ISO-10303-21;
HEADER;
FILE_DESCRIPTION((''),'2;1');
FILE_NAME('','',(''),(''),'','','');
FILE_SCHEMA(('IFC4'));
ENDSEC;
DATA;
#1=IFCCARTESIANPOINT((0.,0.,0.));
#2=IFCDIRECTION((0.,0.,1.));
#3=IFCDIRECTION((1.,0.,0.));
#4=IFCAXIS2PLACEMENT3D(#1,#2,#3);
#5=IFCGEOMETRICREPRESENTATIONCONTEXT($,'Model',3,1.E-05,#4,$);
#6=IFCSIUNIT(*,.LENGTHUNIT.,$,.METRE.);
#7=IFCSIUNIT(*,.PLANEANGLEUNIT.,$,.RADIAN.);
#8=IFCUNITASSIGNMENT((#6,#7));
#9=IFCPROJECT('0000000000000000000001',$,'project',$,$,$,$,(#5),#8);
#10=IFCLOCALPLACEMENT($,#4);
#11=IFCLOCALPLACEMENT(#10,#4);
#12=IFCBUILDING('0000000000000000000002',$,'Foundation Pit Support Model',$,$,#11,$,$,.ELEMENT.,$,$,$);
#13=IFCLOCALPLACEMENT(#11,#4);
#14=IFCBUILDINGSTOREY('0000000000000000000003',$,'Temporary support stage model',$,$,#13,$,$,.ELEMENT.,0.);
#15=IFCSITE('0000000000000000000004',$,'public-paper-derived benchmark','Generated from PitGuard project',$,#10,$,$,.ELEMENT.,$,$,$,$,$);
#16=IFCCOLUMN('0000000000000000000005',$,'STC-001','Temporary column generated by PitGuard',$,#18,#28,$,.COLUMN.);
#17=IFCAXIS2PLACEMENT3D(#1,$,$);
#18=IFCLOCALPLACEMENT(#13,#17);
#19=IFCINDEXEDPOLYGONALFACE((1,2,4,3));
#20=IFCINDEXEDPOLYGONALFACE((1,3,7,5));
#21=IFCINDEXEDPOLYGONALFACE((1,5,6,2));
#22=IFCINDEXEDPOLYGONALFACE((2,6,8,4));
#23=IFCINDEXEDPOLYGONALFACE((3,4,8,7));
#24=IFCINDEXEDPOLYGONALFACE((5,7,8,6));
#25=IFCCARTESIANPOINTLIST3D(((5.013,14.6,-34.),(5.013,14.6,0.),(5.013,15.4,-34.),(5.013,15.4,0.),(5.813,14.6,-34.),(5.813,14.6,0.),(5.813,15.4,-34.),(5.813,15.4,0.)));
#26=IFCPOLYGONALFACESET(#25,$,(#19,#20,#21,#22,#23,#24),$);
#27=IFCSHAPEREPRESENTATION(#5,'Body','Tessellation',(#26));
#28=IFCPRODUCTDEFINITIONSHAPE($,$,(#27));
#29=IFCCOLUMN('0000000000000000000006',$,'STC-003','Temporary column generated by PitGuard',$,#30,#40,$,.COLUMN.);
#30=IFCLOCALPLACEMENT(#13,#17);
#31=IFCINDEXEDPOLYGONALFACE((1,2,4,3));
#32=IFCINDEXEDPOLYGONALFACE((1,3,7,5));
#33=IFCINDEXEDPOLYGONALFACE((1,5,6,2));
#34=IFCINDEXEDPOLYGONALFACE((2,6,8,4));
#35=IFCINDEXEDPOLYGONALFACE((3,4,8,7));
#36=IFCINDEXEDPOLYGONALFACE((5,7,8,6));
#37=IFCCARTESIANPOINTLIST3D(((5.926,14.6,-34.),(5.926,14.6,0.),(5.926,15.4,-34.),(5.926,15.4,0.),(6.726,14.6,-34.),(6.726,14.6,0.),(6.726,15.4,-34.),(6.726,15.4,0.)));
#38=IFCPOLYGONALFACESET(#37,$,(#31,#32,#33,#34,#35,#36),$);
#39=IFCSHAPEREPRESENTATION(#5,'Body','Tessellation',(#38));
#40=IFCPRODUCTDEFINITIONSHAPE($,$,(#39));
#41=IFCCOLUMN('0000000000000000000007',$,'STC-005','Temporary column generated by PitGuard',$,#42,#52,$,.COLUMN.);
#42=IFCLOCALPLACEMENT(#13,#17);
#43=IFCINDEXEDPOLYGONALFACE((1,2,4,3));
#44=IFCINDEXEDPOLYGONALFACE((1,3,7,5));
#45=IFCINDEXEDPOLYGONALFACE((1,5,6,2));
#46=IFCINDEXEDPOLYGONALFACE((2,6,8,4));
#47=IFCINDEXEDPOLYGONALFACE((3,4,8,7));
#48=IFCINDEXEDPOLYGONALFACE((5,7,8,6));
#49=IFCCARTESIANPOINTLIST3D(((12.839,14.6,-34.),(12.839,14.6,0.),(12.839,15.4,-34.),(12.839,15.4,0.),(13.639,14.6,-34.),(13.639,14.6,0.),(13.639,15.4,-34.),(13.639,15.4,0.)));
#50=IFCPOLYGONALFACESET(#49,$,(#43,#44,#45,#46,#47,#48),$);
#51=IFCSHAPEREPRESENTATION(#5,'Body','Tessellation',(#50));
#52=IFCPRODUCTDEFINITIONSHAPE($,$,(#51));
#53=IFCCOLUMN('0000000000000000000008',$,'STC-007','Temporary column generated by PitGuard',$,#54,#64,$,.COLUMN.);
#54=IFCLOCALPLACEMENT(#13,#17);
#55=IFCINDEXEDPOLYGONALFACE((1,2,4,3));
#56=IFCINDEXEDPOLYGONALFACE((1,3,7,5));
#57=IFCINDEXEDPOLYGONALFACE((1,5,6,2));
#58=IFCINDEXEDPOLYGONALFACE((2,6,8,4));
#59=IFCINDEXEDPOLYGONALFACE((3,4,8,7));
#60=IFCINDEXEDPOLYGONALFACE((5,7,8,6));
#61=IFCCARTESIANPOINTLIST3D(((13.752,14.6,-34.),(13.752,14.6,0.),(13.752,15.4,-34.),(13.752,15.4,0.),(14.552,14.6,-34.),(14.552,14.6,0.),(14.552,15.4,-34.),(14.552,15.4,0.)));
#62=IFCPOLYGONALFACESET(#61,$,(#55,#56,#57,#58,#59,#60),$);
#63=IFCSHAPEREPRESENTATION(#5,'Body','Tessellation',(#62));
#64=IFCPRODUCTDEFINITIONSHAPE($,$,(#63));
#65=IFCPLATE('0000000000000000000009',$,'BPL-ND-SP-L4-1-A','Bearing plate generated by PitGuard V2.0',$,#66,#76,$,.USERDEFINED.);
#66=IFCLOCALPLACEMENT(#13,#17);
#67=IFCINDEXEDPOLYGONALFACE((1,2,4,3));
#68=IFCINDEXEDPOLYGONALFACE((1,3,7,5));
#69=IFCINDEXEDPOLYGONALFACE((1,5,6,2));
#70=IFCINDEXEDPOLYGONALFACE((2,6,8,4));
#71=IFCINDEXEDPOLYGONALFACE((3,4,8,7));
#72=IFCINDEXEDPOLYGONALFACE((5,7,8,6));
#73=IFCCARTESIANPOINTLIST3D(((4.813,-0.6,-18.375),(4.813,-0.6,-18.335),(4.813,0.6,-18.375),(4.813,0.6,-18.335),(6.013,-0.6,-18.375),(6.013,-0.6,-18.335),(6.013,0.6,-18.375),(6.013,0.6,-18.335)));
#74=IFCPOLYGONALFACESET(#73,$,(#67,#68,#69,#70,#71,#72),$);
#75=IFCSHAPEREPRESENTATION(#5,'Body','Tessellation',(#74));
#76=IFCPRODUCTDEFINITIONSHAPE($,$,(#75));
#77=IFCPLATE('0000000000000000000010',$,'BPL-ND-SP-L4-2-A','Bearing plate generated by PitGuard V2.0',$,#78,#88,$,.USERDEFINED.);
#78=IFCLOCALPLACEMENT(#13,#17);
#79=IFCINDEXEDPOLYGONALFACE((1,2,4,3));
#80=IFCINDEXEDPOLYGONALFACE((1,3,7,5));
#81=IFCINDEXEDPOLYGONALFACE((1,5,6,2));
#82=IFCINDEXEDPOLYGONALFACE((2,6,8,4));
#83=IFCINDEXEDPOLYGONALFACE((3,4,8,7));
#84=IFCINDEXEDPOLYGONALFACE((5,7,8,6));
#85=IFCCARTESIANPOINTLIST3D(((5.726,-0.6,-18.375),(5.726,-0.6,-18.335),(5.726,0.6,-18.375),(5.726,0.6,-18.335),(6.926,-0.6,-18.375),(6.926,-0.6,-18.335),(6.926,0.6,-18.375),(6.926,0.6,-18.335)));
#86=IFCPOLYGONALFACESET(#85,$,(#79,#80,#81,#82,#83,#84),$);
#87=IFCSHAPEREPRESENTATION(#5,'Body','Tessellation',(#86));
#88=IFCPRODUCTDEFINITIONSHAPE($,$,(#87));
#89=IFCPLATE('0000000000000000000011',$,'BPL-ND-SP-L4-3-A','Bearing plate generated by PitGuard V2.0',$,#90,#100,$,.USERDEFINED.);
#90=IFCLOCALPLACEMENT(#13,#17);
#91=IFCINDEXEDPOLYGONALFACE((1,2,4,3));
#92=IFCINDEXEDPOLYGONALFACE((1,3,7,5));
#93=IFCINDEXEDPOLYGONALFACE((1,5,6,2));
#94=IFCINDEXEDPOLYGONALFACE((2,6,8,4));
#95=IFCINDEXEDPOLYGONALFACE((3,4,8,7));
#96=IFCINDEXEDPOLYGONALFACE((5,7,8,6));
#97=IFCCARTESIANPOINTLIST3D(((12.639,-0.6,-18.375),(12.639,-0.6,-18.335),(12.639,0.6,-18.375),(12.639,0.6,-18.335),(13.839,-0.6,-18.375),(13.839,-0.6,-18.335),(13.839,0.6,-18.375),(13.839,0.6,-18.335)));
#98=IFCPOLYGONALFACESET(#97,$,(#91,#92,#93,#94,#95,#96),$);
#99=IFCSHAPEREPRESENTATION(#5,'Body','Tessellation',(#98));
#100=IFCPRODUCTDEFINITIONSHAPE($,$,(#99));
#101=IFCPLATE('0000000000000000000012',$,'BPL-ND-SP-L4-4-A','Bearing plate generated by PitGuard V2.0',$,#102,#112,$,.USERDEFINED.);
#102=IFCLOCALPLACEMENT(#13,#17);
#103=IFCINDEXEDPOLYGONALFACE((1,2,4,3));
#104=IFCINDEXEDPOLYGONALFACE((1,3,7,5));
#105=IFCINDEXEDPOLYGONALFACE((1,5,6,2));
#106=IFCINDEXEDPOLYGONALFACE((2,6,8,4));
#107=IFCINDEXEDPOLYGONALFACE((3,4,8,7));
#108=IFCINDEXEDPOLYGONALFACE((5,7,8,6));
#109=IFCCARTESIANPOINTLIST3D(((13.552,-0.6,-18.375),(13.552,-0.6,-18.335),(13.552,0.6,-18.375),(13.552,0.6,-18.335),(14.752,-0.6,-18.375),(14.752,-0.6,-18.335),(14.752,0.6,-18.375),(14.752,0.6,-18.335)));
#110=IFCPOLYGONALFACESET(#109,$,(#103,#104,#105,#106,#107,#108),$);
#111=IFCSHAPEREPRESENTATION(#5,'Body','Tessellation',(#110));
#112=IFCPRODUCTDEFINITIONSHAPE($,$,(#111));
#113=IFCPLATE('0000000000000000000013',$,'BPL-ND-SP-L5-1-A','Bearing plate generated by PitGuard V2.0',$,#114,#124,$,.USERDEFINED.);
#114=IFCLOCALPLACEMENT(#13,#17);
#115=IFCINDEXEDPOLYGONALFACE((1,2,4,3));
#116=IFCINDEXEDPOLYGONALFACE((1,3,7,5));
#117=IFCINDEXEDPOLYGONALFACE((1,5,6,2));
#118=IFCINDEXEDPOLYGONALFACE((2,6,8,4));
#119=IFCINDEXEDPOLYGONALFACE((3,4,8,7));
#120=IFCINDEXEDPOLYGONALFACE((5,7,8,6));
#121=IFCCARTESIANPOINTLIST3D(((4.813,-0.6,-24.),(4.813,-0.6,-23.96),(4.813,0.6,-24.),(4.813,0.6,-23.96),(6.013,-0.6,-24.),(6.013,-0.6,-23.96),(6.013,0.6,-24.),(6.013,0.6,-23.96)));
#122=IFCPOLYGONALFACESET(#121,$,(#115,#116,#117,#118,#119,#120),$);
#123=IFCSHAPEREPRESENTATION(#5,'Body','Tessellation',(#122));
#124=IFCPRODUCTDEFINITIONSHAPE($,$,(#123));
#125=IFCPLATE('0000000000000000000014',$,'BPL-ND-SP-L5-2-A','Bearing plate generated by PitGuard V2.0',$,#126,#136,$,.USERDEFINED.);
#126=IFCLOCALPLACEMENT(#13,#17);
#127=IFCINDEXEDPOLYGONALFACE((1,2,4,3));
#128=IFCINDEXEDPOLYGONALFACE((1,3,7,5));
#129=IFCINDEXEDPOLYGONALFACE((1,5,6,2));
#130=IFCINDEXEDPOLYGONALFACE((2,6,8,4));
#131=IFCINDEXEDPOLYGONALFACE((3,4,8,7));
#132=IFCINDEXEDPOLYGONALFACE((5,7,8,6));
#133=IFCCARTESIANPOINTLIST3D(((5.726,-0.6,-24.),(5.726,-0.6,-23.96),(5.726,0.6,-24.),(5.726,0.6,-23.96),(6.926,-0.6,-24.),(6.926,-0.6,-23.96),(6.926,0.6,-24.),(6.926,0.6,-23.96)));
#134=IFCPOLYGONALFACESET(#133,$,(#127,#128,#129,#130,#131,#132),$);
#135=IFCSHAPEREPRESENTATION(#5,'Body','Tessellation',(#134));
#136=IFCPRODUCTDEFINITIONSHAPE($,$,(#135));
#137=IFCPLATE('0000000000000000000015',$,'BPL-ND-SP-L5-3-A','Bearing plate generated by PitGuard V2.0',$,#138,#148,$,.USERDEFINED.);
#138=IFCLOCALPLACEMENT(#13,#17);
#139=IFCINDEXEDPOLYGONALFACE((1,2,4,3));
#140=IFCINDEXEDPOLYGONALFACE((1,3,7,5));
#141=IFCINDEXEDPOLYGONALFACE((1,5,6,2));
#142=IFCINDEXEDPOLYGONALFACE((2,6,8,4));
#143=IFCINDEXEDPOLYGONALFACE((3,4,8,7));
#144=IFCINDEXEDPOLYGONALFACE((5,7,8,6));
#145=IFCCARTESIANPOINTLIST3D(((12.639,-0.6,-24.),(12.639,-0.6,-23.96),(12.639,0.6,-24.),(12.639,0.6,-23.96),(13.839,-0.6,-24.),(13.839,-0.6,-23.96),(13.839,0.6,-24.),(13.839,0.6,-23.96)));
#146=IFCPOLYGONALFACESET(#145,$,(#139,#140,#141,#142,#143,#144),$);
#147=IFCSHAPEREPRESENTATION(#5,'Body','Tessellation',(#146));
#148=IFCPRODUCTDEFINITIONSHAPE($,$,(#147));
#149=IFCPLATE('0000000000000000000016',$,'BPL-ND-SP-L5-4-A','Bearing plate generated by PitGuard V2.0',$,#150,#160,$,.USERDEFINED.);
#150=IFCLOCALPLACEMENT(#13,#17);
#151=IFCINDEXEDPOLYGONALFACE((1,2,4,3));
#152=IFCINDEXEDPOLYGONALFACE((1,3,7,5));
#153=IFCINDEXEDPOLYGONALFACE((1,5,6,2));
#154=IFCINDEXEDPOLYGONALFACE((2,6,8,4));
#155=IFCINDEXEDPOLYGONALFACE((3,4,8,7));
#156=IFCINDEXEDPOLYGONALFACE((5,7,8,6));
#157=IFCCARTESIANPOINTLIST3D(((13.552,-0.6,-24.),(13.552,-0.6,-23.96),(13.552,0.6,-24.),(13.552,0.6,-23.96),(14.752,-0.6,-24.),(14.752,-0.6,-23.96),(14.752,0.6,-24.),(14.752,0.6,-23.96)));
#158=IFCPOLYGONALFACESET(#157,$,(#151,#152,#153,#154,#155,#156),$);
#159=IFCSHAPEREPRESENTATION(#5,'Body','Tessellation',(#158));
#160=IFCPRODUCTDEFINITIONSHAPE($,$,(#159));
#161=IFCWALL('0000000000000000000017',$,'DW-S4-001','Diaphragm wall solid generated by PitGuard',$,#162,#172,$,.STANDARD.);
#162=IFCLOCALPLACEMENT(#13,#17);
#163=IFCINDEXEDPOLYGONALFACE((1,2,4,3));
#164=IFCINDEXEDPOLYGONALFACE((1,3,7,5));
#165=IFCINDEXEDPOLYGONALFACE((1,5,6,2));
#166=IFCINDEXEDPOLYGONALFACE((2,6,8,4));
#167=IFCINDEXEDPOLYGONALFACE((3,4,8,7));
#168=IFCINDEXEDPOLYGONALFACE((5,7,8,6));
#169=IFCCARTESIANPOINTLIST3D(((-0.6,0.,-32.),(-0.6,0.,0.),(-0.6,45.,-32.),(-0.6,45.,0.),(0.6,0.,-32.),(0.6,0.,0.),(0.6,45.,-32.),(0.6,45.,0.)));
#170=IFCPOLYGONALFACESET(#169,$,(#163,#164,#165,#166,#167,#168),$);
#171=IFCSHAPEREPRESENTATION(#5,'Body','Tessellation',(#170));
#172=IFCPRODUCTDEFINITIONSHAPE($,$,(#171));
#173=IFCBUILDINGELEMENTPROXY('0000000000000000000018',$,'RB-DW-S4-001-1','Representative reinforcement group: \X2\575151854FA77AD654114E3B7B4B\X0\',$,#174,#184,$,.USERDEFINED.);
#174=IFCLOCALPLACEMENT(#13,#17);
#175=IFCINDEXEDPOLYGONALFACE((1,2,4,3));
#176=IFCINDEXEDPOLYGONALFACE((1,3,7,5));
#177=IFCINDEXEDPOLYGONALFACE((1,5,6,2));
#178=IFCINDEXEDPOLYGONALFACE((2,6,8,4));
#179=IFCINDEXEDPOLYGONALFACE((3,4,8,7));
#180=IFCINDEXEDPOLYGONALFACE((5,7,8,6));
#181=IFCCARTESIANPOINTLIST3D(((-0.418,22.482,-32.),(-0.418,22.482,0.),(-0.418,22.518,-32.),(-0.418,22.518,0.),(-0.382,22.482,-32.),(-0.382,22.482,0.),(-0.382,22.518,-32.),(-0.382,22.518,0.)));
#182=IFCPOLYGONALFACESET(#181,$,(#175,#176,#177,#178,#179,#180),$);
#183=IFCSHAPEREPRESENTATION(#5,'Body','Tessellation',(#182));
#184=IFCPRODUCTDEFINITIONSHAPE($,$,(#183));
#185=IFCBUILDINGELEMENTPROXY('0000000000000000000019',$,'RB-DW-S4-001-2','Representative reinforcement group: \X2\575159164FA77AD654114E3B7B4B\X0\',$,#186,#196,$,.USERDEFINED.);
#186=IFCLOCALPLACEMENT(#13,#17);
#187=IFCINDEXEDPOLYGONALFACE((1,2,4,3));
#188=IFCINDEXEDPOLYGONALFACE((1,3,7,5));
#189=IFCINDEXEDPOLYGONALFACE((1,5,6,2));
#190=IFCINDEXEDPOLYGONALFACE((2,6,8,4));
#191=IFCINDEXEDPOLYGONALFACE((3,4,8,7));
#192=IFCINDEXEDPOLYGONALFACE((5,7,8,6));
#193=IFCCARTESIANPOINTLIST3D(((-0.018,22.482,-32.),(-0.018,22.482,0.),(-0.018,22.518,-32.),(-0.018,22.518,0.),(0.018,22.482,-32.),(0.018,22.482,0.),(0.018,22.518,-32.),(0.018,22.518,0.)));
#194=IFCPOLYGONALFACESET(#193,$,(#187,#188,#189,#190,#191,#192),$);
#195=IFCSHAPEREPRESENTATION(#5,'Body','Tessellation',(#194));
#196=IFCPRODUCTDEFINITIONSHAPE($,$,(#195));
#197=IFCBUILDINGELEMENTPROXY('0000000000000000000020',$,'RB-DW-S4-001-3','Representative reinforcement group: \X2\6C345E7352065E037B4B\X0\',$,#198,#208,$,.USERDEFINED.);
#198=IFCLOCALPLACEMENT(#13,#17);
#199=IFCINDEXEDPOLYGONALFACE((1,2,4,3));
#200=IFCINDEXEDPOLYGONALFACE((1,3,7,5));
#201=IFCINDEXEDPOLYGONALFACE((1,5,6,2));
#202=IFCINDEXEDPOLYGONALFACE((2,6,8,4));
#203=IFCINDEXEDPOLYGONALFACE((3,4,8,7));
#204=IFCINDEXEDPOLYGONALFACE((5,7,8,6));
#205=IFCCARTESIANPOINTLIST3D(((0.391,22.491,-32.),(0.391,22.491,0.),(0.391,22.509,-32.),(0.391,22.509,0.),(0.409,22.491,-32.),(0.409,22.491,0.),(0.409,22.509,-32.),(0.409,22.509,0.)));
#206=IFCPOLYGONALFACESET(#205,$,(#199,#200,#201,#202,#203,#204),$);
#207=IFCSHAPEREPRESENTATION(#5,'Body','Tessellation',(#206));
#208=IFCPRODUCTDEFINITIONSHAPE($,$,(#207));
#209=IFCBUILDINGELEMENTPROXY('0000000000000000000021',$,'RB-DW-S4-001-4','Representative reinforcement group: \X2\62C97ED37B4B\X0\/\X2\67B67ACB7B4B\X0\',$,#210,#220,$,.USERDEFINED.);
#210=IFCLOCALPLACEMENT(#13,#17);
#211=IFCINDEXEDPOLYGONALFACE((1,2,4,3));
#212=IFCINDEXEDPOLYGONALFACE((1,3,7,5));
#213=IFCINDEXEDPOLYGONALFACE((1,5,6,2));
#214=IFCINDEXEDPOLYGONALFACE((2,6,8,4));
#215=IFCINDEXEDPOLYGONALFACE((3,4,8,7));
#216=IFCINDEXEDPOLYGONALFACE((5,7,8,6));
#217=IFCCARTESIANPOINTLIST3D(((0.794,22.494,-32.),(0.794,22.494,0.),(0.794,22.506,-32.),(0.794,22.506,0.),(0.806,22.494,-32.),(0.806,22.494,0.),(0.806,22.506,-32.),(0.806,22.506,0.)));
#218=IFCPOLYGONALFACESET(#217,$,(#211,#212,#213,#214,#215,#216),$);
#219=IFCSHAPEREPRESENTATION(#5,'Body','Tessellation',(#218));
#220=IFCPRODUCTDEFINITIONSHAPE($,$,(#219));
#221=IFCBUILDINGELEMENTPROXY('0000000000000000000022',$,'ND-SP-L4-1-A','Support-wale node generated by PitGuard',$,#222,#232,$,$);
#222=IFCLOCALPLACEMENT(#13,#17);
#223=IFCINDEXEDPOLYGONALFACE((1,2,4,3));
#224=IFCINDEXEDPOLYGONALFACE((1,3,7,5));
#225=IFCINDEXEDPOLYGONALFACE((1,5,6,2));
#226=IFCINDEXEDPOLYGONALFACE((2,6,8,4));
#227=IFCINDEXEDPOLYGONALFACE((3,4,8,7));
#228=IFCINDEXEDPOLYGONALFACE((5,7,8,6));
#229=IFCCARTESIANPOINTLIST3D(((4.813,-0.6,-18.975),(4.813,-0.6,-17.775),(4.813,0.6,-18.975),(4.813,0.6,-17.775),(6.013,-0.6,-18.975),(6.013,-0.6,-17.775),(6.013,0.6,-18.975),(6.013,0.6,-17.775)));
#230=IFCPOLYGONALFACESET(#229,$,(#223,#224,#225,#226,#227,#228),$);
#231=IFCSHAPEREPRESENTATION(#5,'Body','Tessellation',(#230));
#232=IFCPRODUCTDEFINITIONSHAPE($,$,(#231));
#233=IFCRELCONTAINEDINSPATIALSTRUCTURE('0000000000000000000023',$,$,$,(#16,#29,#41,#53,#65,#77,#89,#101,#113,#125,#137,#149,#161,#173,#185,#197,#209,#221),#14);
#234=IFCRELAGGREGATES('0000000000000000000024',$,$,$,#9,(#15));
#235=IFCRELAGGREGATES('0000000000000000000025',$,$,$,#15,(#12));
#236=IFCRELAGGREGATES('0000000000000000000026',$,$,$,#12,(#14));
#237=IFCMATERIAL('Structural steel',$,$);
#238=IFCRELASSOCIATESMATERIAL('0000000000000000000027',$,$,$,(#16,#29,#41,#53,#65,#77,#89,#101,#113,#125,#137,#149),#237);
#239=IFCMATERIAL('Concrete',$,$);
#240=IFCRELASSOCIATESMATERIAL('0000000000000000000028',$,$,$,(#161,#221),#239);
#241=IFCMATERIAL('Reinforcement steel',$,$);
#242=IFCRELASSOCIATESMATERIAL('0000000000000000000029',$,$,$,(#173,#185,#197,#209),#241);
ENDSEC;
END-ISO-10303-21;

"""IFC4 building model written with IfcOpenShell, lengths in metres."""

from ifc_helpers import new_model, si_unit, frame, origin_with_axes, origin_2d, place, context, project, spatial, rectangle, extrude, material, element, save


model = new_model("IFC4")

# Units and contexts
model_context = context("Model", 3, precision=1e-05, world=origin_with_axes())
ifc_project = project(units=[si_unit("LENGTHUNIT", "METRE"), si_unit("PLANEANGLEUNIT", "RADIAN")], contexts=[model_context])

# Site, building, storey
site_placement = place(None, origin_with_axes())
site = spatial("IfcSite", under=ifc_project, at=site_placement, Name="public-paper-derived benchmark", Description="Generated from PitGuard project", CompositionType="ELEMENT")
building_placement = place(site_placement, origin_with_axes())
building = spatial("IfcBuilding", under=site, at=building_placement, Name="Foundation Pit Support Model", CompositionType="ELEMENT")
storey_placement = place(building_placement, origin_with_axes())
storey = spatial("IfcBuildingStorey", under=building, at=storey_placement, Name="Temporary support stage model", CompositionType="ELEMENT", Elevation=0.0)

# Columns
ifc_material_1 = material(Name="Structural steel")
for number, where, z_axis, x_axis, name in (
    (1, (5.413, 15.0, -34.0), (0.0, 0.0, 1.0), (1.0, 0.0, 0.0), "STC-001"),
    (2, (6.326, 15.0, -34.0), (0.0, 0.0, 1.0), (1.0, 0.0, 0.0), "STC-003"),
    (3, (13.239, 15.0, -34.0), (0.0, 0.0, 1.0), (1.0, 0.0, 0.0), "STC-005"),
    (4, (14.152, 15.0, -34.0), (0.0, 0.0, 1.0), (1.0, 0.0, 0.0), "STC-007"),
):
    element("IfcColumn", number, at=place(storey_placement, frame(where, z_axis=z_axis, x_axis=x_axis)), inside=storey, material=ifc_material_1, Name=name, Description="Temporary column generated by PitGuard", PredefinedType="COLUMN", context=model_context, shape_type="SweptSolid", body=[
        extrude(rectangle(XDim=0.8, YDim=0.8, at=origin_2d()), origin_with_axes(), (0.0, 0.0, 1.0), 34.0),
    ])

# Plates
for number, where, z_axis, x_axis, name in (
    (5, (5.413, 0.0, -18.375), (0.0, 0.0, 1.0), (1.0, 0.0, 0.0), "BPL-ND-SP-L4-1-A"),
    (6, (6.326, 0.0, -18.375), (0.0, 0.0, 1.0), (1.0, 0.0, 0.0), "BPL-ND-SP-L4-2-A"),
    (7, (13.239, 0.0, -18.375), (0.0, 0.0, 1.0), (1.0, 0.0, 0.0), "BPL-ND-SP-L4-3-A"),
    (8, (14.152, 0.0, -18.375), (0.0, 0.0, 1.0), (1.0, 0.0, 0.0), "BPL-ND-SP-L4-4-A"),
    (9, (5.413, 0.0, -24.0), (0.0, 0.0, 1.0), (1.0, 0.0, 0.0), "BPL-ND-SP-L5-1-A"),
    (10, (6.326, 0.0, -24.0), (0.0, 0.0, 1.0), (1.0, 0.0, 0.0), "BPL-ND-SP-L5-2-A"),
    (11, (13.239, 0.0, -24.0), (0.0, 0.0, 1.0), (1.0, 0.0, 0.0), "BPL-ND-SP-L5-3-A"),
    (12, (14.152, 0.0, -24.0), (0.0, 0.0, 1.0), (1.0, 0.0, 0.0), "BPL-ND-SP-L5-4-A"),
):
    element("IfcPlate", number, at=place(storey_placement, frame(where, z_axis=z_axis, x_axis=x_axis)), inside=storey, material=ifc_material_1, Name=name, Description="Bearing plate generated by PitGuard V2.0", PredefinedType="USERDEFINED", context=model_context, shape_type="SweptSolid", body=[
        extrude(rectangle(XDim=1.2, YDim=1.2, at=origin_2d()), origin_with_axes(), (0.0, 0.0, 1.0), 0.04),
    ])

# Wall
ifc_material_2 = material(Name="Concrete")
wall_placement = place(storey_placement, frame((0.0, 22.5, -32.0), z_axis=(0.0, 0.0, 1.0), x_axis=(0.0, -1.0, 0.0)))
element("IfcWall", 13, at=wall_placement, inside=storey, material=ifc_material_2, Name="DW-S4-001", Description="Diaphragm wall solid generated by PitGuard", PredefinedType="STANDARD", context=model_context, shape_type="SweptSolid", body=[
    extrude(rectangle(XDim=45.0, YDim=1.2, at=origin_2d()), origin_with_axes(), (0.0, 0.0, 1.0), 32.0),
])

# Building element proxies
ifc_material_3 = material(Name="Reinforcement steel")
for number, where, z_axis, x_axis, name, description in (
    (14, (-0.4, 22.5, -32.0), (0.0, 0.0, 1.0), (1.0, 0.0, 0.0), "RB-DW-S4-001-1", "Representative reinforcement group: 坑内侧竖向主筋"),
    (15, (0.0, 22.5, -32.0), (0.0, 0.0, 1.0), (1.0, 0.0, 0.0), "RB-DW-S4-001-2", "Representative reinforcement group: 坑外侧竖向主筋"),
):
    element("IfcBuildingElementProxy", number, at=place(storey_placement, frame(where, z_axis=z_axis, x_axis=x_axis)), inside=storey, material=ifc_material_3, Name=name, Description=description, PredefinedType="USERDEFINED", context=model_context, shape_type="SweptSolid", body=[
        extrude(rectangle(XDim=0.036, YDim=0.036, at=origin_2d()), origin_with_axes(), (0.0, 0.0, 1.0), 32.0),
    ])
proxy_1_placement = place(storey_placement, frame((0.4, 22.5, -32.0), z_axis=(0.0, 0.0, 1.0), x_axis=(1.0, 0.0, 0.0)))
element("IfcBuildingElementProxy", 16, at=proxy_1_placement, inside=storey, material=ifc_material_3, Name="RB-DW-S4-001-3", Description="Representative reinforcement group: 水平分布筋", PredefinedType="USERDEFINED", context=model_context, shape_type="SweptSolid", body=[
    extrude(rectangle(XDim=0.018, YDim=0.018, at=origin_2d()), origin_with_axes(), (0.0, 0.0, 1.0), 32.0),
])
proxy_2_placement = place(storey_placement, frame((0.8, 22.5, -32.0), z_axis=(0.0, 0.0, 1.0), x_axis=(1.0, 0.0, 0.0)))
element("IfcBuildingElementProxy", 17, at=proxy_2_placement, inside=storey, material=ifc_material_3, Name="RB-DW-S4-001-4", Description="Representative reinforcement group: 拉结筋/架立筋", PredefinedType="USERDEFINED", context=model_context, shape_type="SweptSolid", body=[
    extrude(rectangle(XDim=0.012, YDim=0.012, at=origin_2d()), origin_with_axes(), (0.0, 0.0, 1.0), 32.0),
])
proxy_3_placement = place(storey_placement, frame((5.413, 0.0, -18.975), z_axis=(0.0, 0.0, 1.0), x_axis=(1.0, 0.0, 0.0)))
element("IfcBuildingElementProxy", 18, at=proxy_3_placement, inside=storey, material=ifc_material_2, Name="ND-SP-L4-1-A", Description="Support-wale node generated by PitGuard", context=model_context, shape_type="SweptSolid", body=[
    extrude(rectangle(XDim=1.2, YDim=1.2, at=origin_2d()), origin_with_axes(), (0.0, 0.0, 1.0), 1.2),
])

save(model, "model.ifc")
